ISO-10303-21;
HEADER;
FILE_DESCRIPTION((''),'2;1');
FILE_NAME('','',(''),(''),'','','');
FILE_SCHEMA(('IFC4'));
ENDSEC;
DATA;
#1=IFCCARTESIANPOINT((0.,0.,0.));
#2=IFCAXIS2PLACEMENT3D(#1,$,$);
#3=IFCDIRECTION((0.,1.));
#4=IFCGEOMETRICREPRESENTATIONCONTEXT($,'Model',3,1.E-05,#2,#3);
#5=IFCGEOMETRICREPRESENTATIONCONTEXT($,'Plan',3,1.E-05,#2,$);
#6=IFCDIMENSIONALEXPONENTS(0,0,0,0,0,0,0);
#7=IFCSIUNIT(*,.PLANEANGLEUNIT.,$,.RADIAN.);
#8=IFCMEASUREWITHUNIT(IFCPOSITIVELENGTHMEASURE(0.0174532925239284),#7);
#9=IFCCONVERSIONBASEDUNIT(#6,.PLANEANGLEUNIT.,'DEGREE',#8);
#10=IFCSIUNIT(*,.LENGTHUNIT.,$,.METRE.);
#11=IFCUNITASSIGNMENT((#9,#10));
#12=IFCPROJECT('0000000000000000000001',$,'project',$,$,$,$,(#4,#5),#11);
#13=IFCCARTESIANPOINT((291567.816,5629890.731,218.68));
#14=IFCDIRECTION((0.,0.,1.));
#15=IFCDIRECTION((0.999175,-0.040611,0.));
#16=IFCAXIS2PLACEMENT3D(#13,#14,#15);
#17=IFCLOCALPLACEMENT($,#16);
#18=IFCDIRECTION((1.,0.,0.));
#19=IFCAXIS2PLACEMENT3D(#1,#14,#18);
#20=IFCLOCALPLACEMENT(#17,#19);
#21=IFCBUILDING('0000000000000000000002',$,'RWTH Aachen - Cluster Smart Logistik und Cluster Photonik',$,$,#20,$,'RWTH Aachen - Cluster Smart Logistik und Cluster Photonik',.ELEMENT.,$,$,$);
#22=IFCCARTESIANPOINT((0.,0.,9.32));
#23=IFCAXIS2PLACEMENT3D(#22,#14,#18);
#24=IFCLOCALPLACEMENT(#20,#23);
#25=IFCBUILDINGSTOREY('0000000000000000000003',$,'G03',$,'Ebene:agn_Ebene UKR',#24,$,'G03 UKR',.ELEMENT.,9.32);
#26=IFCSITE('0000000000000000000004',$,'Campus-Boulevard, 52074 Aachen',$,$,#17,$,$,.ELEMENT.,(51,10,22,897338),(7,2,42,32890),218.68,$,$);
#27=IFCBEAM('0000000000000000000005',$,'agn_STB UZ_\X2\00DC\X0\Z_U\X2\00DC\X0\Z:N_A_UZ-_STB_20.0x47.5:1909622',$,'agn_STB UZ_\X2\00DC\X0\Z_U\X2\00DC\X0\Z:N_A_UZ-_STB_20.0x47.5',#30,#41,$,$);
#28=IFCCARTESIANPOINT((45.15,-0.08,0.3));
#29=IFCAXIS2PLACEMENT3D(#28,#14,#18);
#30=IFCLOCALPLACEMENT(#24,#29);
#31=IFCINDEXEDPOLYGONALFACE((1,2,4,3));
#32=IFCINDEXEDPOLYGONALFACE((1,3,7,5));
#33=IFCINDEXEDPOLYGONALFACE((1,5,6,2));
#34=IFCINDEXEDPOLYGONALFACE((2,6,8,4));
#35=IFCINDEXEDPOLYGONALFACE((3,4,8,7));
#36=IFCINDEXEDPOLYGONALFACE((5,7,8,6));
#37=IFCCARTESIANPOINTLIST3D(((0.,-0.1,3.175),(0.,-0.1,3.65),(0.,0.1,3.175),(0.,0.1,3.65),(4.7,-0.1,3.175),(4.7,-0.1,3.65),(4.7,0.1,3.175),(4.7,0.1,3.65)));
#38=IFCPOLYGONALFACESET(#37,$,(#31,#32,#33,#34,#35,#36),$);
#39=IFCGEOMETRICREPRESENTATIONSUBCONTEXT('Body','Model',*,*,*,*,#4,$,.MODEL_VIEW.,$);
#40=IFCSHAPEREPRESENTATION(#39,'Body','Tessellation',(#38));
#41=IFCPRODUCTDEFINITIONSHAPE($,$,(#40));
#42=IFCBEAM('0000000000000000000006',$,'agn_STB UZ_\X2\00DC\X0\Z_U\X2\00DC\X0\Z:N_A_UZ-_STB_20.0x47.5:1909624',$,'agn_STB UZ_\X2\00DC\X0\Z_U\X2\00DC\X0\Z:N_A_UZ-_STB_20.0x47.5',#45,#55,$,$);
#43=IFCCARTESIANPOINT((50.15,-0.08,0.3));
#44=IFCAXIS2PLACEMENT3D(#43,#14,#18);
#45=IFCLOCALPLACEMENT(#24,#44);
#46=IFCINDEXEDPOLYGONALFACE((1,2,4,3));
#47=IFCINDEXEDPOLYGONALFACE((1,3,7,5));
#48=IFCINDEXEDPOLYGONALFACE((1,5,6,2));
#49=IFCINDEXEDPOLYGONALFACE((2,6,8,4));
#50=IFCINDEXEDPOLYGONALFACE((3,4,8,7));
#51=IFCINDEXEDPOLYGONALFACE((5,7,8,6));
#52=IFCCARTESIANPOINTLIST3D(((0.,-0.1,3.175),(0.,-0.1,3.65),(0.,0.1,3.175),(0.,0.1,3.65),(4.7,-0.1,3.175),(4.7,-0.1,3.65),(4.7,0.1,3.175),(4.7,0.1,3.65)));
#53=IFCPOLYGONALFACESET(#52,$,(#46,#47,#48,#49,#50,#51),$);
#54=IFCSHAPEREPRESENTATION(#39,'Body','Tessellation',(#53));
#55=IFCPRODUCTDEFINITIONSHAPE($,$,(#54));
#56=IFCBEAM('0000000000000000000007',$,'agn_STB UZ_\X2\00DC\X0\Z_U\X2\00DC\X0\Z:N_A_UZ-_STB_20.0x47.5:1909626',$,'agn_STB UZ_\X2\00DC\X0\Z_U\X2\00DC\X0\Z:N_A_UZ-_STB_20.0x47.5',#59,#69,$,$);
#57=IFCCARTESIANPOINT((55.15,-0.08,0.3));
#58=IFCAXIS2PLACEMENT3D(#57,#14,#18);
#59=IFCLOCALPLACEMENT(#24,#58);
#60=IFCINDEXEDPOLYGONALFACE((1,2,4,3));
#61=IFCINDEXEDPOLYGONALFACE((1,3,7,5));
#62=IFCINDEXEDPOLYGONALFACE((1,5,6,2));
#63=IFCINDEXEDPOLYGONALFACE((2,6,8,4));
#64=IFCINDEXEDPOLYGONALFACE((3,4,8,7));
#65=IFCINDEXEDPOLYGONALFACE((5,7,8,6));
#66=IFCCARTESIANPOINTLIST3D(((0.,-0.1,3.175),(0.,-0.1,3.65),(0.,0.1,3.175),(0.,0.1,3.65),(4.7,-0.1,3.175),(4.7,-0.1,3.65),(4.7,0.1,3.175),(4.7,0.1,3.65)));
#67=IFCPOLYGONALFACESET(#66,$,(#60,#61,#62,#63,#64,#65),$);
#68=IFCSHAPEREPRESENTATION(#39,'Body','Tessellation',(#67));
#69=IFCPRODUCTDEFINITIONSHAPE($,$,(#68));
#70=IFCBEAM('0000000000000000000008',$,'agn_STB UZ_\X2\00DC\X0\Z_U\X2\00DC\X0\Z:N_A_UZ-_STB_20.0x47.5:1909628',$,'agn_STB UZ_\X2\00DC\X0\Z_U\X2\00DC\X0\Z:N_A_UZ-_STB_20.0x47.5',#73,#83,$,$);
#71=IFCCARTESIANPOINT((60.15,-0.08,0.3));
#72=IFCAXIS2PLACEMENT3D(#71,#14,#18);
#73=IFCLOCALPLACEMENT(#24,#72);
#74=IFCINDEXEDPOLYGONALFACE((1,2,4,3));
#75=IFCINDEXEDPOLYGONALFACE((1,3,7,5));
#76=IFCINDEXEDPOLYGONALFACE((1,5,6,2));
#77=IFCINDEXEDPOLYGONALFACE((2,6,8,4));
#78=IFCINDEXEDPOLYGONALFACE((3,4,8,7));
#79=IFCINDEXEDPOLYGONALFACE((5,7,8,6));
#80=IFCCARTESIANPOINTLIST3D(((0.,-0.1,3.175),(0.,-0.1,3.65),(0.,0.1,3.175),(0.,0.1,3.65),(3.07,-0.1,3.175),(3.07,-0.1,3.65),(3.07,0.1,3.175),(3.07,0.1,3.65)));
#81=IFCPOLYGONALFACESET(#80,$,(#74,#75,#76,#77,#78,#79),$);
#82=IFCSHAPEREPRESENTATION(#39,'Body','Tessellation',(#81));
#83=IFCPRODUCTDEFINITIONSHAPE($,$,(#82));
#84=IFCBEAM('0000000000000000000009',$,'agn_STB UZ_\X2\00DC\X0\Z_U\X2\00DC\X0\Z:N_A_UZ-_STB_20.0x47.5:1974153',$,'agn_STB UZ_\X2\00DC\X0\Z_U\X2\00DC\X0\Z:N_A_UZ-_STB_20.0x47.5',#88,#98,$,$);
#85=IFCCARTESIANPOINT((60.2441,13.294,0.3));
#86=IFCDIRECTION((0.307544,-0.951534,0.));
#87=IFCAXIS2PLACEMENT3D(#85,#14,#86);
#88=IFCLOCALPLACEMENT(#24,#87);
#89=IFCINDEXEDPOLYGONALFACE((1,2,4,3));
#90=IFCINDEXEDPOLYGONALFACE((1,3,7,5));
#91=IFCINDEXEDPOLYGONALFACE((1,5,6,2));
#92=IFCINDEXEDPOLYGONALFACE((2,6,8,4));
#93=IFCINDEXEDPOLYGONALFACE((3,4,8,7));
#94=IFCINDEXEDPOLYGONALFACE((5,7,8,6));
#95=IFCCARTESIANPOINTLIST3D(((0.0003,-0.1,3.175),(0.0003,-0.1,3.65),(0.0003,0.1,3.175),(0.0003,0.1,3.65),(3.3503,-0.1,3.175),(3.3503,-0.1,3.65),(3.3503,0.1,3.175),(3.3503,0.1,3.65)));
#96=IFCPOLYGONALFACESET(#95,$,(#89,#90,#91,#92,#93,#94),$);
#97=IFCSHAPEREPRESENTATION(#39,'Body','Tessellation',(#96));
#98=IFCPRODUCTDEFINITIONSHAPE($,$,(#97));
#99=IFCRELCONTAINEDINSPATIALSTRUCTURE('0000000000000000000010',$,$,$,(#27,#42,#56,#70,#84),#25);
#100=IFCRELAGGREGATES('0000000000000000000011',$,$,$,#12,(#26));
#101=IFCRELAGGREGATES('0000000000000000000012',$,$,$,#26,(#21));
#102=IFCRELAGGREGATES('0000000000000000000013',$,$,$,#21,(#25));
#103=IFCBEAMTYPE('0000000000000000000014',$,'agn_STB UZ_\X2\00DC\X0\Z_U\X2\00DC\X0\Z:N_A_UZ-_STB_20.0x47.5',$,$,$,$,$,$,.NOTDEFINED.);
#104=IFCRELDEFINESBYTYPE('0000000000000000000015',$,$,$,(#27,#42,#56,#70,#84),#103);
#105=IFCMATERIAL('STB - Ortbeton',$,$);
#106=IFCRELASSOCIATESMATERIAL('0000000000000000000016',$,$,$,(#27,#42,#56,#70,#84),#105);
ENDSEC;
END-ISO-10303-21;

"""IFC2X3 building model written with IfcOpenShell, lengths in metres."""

from ifc_helpers import new_model, entity, si_unit, converted_unit, direction, frame, frame_2d, origin, origin_with_axes, place, context, subcontext, project, spatial, rectangle, extrude, material, type_object, element, save


model = new_model("IFC2X3")

# Units and contexts
model_context = context("Model", 3, precision=1e-05, world=origin(), true_north=direction((0.0, 1.0)))
plan_context = context("Plan", 3, precision=1e-05, world=origin())
body_context = subcontext(model_context, "Body", "Model", "MODEL_VIEW")
ifc_project = project(units=[converted_unit("PLANEANGLEUNIT", "DEGREE", entity("IfcPositiveLengthMeasure", 0.0174532925239284), si_unit("PLANEANGLEUNIT", "RADIAN"), dimensions=[0, 0, 0, 0, 0, 0, 0]), si_unit("LENGTHUNIT", "METRE")], contexts=[model_context, plan_context])

# Site, building, storey
site_placement = place(None, frame((291567.816, 5629890.731, 218.68), z_axis=(0.0, 0.0, 1.0), x_axis=(0.999175, -0.040611, 0.0)))
site = spatial("IfcSite", under=ifc_project, at=site_placement, Name="Campus-Boulevard, 52074 Aachen", CompositionType="ELEMENT", RefLatitude=(51, 10, 22, 897338), RefLongitude=(7, 2, 42, 32890), RefElevation=218.68)
building_placement = place(site_placement, origin_with_axes())
building = spatial("IfcBuilding", under=site, at=building_placement, Name="RWTH Aachen - Cluster Smart Logistik und Cluster Photonik", LongName="RWTH Aachen - Cluster Smart Logistik und Cluster Photonik", CompositionType="ELEMENT")
storey_placement = place(building_placement, frame((0.0, 0.0, 9.32), z_axis=(0.0, 0.0, 1.0), x_axis=(1.0, 0.0, 0.0)))
storey = spatial("IfcBuildingStorey", under=building, at=storey_placement, Name="G03", ObjectType="Ebene:agn_Ebene UKR", LongName="G03 UKR", CompositionType="ELEMENT", Elevation=9.32)

# Beams
ifc_material_1 = material(Name="STB - Ortbeton")
beam_type_1 = type_object("IfcBeamType", Name="agn_STB UZ_ÜZ_UÜZ:N_A_UZ-_STB_20.0x47.5", PredefinedType="NOTDEFINED")
for number, where, z_axis, x_axis, name in (
    (1, (45.15, -0.08, 0.3), (0.0, 0.0, 1.0), (1.0, 0.0, 0.0), "agn_STB UZ_ÜZ_UÜZ:N_A_UZ-_STB_20.0x47.5:1909622"),
    (2, (50.15, -0.08, 0.3), (0.0, 0.0, 1.0), (1.0, 0.0, 0.0), "agn_STB UZ_ÜZ_UÜZ:N_A_UZ-_STB_20.0x47.5:1909624"),
    (3, (55.15, -0.08, 0.3), (0.0, 0.0, 1.0), (1.0, 0.0, 0.0), "agn_STB UZ_ÜZ_UÜZ:N_A_UZ-_STB_20.0x47.5:1909626"),
):
    element("IfcBeam", number, at=place(storey_placement, frame(where, z_axis=z_axis, x_axis=x_axis)), inside=storey, type_object=beam_type_1, material=ifc_material_1, Name=name, ObjectType="agn_STB UZ_ÜZ_UÜZ:N_A_UZ-_STB_20.0x47.5", context=body_context, shape_type="SweptSolid", body=[
        extrude(rectangle(XDim=0.475, YDim=0.2, at=frame_2d((0.0, 0.0), x_axis=(1.0, 0.0))), frame((0.0, 0.0, 3.4125), z_axis=(1.0, 0.0, 0.0), x_axis=(0.0, 0.0, -1.0)), (0.0, 0.0, 1.0), 4.7),
    ])
beam_1_placement = place(storey_placement, frame((60.15, -0.08, 0.3), z_axis=(0.0, 0.0, 1.0), x_axis=(1.0, 0.0, 0.0)))
element("IfcBeam", 4, at=beam_1_placement, inside=storey, type_object=beam_type_1, material=ifc_material_1, Name="agn_STB UZ_ÜZ_UÜZ:N_A_UZ-_STB_20.0x47.5:1909628", ObjectType="agn_STB UZ_ÜZ_UÜZ:N_A_UZ-_STB_20.0x47.5", context=body_context, shape_type="SweptSolid", body=[
    extrude(rectangle(XDim=0.475, YDim=0.2, at=frame_2d((0.0, 0.0), x_axis=(1.0, 0.0))), frame((0.0, 0.0, 3.4125), z_axis=(1.0, 0.0, 0.0), x_axis=(0.0, 0.0, -1.0)), (0.0, 0.0, 1.0), 3.07),
])
beam_2_placement = place(storey_placement, frame((60.2441, 13.294, 0.3), z_axis=(0.0, 0.0, 1.0), x_axis=(0.307544, -0.951534, 0.0)))
element("IfcBeam", 5, at=beam_2_placement, inside=storey, type_object=beam_type_1, material=ifc_material_1, Name="agn_STB UZ_ÜZ_UÜZ:N_A_UZ-_STB_20.0x47.5:1974153", ObjectType="agn_STB UZ_ÜZ_UÜZ:N_A_UZ-_STB_20.0x47.5", context=body_context, shape_type="SweptSolid", body=[
    extrude(rectangle(XDim=0.475, YDim=0.2, at=frame_2d((0.0, 0.0), x_axis=(1.0, 0.0))), frame((0.0003, 0.0, 3.4125), z_axis=(1.0, 0.0, 0.0), x_axis=(0.0, 0.0, -1.0)), (0.0, 0.0, 1.0), 3.35),
])

save(model, "model.ifc")
